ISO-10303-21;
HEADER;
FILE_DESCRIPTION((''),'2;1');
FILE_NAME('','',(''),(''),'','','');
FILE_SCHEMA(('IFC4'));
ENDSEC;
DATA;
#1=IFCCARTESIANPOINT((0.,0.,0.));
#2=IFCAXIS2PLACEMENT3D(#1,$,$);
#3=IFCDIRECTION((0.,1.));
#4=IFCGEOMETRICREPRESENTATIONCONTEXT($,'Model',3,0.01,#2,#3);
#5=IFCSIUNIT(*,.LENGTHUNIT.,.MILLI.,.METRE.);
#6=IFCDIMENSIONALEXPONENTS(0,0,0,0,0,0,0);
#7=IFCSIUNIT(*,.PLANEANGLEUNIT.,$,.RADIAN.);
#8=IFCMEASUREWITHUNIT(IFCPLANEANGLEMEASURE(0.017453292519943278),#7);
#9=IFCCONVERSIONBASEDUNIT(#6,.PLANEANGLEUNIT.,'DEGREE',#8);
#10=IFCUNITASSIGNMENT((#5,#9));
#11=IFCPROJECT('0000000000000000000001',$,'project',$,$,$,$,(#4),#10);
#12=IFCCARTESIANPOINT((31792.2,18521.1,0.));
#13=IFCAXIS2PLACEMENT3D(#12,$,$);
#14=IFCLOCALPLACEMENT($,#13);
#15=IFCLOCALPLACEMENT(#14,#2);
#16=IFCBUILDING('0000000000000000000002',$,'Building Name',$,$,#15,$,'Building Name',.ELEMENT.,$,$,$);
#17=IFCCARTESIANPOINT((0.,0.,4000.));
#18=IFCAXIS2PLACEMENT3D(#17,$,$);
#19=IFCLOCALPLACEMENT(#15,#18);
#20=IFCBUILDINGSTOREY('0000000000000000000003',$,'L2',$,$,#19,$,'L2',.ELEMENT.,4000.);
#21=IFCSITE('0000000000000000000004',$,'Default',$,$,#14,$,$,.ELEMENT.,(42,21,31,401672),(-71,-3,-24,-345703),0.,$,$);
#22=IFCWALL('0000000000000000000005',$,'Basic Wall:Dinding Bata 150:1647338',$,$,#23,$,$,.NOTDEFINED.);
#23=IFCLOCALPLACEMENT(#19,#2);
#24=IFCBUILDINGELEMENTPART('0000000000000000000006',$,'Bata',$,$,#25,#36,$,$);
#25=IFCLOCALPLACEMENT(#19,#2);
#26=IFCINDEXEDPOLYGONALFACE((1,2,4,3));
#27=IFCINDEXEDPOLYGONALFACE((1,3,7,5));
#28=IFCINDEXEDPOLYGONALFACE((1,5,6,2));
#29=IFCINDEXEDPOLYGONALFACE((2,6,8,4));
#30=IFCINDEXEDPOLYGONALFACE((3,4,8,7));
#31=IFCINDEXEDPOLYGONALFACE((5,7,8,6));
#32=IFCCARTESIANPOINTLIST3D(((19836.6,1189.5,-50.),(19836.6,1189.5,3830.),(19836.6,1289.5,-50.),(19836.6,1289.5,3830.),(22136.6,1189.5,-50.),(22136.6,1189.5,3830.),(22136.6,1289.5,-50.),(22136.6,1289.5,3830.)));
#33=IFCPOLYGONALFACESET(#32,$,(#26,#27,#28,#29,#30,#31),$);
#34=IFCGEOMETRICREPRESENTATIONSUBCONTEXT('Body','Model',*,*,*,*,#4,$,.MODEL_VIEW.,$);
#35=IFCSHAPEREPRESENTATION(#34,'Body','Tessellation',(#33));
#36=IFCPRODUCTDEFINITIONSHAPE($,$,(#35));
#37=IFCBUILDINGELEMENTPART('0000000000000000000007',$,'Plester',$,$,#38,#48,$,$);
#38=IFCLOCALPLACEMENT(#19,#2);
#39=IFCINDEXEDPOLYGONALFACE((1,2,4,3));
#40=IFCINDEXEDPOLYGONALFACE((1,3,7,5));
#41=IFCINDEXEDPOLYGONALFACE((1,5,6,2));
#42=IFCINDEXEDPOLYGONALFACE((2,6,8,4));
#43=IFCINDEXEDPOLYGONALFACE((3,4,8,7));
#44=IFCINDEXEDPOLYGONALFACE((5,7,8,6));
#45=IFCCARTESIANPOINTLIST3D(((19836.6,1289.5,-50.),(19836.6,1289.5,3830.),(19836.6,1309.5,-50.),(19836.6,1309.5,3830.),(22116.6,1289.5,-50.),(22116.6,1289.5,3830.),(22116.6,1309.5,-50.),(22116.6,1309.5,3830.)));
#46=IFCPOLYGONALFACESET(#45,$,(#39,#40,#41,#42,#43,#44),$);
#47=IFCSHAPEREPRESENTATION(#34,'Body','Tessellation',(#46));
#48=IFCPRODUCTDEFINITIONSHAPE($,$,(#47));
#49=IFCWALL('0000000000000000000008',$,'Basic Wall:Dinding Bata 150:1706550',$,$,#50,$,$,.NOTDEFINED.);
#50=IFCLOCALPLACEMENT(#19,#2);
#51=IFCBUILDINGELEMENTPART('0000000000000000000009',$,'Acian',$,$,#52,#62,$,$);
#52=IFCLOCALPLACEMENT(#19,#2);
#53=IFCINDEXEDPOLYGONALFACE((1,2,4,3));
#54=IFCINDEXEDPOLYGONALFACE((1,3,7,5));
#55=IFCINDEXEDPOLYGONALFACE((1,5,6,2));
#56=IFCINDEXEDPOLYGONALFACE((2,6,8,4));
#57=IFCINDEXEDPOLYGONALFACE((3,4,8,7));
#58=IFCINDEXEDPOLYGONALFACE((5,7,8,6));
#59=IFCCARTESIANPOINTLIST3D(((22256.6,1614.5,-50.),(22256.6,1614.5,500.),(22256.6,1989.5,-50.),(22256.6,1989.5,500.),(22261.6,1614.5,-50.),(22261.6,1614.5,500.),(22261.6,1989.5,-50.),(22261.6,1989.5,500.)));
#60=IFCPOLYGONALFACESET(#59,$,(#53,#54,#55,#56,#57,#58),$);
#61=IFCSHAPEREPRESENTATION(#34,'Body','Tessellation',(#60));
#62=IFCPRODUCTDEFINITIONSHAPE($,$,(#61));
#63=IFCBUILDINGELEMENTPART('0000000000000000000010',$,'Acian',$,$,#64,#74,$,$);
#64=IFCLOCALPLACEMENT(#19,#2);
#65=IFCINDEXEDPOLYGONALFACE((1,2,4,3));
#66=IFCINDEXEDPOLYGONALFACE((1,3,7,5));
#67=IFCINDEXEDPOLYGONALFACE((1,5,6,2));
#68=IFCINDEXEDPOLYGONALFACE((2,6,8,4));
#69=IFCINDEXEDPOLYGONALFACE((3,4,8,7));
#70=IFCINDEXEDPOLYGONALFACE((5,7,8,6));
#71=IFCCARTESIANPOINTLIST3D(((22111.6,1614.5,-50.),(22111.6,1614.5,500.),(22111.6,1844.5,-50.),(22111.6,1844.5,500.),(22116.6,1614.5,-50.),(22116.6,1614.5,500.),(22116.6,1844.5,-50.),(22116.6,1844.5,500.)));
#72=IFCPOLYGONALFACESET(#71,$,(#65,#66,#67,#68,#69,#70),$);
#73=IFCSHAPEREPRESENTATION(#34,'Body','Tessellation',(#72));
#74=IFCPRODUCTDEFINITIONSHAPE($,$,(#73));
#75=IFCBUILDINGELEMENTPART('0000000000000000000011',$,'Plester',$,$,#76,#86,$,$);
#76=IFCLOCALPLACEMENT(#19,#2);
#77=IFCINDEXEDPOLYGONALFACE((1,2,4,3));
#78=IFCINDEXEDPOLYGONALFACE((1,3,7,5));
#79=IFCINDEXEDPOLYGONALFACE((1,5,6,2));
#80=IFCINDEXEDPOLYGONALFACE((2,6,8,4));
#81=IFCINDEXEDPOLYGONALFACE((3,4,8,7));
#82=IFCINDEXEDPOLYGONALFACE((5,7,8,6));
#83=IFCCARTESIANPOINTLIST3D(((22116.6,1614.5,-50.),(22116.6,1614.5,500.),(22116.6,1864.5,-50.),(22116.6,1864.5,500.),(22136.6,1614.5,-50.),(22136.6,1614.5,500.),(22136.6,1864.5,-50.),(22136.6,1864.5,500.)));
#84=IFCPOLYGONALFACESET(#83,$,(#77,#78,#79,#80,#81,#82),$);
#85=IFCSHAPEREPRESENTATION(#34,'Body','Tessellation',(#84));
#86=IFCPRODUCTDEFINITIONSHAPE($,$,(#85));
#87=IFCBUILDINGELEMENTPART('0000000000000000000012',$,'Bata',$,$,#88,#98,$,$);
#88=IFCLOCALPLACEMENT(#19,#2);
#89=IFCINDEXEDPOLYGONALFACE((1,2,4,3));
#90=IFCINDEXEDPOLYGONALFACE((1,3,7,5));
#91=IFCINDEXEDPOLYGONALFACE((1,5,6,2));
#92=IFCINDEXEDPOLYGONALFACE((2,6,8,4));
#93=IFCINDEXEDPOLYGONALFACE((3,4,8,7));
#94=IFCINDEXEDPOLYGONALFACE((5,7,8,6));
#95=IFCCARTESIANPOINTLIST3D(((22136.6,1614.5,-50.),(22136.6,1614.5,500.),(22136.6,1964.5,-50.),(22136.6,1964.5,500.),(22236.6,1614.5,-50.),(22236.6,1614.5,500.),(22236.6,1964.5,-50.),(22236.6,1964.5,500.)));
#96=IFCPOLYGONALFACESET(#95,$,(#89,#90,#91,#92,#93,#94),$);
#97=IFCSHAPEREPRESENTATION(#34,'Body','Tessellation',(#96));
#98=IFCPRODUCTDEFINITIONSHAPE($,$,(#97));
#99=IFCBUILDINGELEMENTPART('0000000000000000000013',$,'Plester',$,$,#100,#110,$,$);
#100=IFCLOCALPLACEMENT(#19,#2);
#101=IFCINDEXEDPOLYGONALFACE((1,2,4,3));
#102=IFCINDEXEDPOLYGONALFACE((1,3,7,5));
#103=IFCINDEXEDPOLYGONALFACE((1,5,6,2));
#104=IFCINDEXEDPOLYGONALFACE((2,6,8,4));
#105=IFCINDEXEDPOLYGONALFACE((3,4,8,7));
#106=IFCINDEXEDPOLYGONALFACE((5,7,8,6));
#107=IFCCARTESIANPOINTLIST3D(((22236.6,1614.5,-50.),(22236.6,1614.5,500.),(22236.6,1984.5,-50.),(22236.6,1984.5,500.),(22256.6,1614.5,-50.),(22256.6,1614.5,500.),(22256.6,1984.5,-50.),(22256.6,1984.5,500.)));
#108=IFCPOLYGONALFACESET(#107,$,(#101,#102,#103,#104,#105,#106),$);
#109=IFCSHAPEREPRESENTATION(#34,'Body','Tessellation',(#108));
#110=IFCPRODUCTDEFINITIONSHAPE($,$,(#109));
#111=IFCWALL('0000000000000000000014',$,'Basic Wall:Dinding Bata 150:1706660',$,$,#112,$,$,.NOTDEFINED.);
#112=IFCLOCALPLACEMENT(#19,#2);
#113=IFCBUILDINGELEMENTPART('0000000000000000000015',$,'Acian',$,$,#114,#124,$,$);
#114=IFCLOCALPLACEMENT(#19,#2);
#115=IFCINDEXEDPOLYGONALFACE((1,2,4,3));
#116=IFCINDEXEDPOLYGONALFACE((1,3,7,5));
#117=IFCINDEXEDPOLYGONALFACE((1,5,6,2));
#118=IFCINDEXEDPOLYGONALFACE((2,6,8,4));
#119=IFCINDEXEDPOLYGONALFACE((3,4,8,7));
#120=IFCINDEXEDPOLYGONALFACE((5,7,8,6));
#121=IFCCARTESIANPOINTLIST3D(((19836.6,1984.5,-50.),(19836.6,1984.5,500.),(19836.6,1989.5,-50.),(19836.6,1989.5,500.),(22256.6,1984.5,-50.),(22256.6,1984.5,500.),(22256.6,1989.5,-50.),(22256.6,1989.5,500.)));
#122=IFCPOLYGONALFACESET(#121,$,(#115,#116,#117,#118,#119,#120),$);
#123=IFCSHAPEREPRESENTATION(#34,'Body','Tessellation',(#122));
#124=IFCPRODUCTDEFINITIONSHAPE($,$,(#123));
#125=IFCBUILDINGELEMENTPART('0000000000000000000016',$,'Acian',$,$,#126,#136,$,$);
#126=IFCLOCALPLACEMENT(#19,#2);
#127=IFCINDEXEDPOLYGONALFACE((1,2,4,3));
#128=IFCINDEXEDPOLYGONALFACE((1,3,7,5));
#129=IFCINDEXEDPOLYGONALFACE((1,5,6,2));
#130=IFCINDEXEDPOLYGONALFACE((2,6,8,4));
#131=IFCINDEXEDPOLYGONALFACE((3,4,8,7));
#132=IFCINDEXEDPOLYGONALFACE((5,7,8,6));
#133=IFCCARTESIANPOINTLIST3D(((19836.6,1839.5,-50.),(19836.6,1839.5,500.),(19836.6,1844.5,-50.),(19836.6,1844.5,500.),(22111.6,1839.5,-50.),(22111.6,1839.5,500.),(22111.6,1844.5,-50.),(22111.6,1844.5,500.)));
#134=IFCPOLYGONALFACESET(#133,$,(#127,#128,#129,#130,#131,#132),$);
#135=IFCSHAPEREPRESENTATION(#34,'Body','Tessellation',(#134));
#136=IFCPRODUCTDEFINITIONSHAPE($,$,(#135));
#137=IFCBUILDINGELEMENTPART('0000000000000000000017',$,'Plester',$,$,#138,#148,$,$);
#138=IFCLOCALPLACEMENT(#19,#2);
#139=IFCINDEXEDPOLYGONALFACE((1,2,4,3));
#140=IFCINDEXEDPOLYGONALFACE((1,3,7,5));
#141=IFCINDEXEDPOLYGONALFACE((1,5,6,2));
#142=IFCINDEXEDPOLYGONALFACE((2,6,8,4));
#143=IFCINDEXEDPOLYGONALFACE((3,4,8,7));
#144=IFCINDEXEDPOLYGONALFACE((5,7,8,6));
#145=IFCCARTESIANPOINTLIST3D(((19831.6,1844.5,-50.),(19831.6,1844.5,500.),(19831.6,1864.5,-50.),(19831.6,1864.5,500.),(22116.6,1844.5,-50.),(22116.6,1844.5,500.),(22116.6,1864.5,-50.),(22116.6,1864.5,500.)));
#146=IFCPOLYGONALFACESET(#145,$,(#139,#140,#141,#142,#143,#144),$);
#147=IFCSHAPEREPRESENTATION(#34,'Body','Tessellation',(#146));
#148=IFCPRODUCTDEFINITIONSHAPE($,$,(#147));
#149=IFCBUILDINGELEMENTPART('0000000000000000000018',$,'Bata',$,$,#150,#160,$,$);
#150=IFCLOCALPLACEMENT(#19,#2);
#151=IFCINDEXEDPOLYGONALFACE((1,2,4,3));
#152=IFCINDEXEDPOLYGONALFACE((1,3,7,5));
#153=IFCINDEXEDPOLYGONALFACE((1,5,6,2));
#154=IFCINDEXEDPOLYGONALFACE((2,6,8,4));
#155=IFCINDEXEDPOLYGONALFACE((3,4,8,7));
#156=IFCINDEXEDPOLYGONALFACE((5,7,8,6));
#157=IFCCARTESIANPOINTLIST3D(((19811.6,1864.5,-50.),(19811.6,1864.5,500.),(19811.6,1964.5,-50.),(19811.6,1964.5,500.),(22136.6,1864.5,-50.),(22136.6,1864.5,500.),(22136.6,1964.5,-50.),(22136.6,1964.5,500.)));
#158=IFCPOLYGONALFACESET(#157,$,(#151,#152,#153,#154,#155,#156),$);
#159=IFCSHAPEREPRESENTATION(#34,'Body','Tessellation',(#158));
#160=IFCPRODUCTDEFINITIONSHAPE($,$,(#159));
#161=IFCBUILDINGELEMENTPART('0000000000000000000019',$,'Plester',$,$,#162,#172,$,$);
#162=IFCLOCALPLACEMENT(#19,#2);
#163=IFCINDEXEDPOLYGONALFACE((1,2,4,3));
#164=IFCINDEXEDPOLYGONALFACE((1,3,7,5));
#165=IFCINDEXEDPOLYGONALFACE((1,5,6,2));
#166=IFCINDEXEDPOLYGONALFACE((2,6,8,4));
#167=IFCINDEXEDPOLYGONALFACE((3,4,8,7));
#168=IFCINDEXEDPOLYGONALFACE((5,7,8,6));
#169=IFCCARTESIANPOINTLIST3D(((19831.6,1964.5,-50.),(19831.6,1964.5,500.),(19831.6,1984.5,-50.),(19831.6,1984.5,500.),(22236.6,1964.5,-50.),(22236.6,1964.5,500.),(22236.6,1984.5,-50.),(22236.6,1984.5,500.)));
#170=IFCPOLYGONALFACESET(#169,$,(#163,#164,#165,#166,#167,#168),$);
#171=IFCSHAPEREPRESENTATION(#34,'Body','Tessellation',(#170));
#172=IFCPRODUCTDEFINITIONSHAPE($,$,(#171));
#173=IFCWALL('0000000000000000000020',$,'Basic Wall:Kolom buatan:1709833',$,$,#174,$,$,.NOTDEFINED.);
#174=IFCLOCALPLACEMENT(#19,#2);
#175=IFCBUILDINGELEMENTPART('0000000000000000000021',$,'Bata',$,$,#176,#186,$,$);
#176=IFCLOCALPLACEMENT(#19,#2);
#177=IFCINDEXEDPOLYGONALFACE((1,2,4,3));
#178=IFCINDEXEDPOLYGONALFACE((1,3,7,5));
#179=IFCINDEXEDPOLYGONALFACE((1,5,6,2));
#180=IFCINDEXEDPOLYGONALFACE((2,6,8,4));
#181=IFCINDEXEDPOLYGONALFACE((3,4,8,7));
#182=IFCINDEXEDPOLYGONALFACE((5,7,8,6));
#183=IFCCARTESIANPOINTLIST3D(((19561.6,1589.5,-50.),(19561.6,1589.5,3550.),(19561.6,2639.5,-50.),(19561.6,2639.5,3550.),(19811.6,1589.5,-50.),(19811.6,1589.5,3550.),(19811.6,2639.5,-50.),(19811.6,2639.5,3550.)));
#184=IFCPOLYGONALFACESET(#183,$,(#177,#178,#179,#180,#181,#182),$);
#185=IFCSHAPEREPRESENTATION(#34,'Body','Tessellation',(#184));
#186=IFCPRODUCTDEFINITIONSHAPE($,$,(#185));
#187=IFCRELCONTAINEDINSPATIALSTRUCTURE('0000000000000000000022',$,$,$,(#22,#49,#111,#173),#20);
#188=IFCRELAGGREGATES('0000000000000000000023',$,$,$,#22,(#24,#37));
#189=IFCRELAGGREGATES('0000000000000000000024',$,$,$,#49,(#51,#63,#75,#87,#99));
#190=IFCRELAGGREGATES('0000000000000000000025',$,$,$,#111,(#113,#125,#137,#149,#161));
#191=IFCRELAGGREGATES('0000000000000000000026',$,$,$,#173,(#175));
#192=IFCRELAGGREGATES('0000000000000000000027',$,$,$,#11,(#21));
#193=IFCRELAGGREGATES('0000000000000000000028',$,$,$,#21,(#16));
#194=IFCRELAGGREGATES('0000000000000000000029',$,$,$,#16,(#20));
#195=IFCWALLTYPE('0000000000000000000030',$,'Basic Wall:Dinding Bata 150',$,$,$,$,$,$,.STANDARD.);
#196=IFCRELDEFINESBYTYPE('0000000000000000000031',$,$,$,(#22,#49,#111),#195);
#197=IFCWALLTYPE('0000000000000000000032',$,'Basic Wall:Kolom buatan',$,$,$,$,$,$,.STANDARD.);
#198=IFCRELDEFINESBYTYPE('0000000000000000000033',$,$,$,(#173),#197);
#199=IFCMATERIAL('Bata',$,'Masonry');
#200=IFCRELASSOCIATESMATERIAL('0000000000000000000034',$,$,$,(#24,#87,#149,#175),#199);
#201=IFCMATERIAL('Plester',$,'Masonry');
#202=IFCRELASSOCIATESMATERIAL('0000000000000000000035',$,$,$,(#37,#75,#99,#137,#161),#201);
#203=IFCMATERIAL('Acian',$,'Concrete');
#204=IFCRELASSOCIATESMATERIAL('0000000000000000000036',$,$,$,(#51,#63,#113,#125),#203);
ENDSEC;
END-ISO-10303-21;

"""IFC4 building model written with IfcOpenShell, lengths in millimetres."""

from ifc_helpers import new_model, entity, si_unit, converted_unit, direction, frame, origin, place, context, subcontext, project, spatial, indexed_curve, outline, extrude, material, type_object, element, aggregate, save


model = new_model("IFC4")

# Units and contexts
model_context = context("Model", 3, precision=0.01, world=origin(), true_north=direction((0.0, 1.0)))
body_context = subcontext(model_context, "Body", "Model", "MODEL_VIEW")
ifc_project = project(units=[si_unit("LENGTHUNIT", "METRE", prefix="MILLI"), converted_unit("PLANEANGLEUNIT", "DEGREE", entity("IfcPlaneAngleMeasure", 0.017453292519943278), si_unit("PLANEANGLEUNIT", "RADIAN"), dimensions=[0, 0, 0, 0, 0, 0, 0])], contexts=[model_context])

# Site, building, storey
site_placement = place(None, frame((31792.2, 18521.1, 0.0)))
site = spatial("IfcSite", under=ifc_project, at=site_placement, Name="Default", CompositionType="ELEMENT", RefLatitude=(42, 21, 31, 401672), RefLongitude=(-71, -3, -24, -345703), RefElevation=0.0)
building_placement = place(site_placement, origin())
building = spatial("IfcBuilding", under=site, at=building_placement, Name="Building Name", LongName="Building Name", CompositionType="ELEMENT")
storey_placement = place(building_placement, frame((0.0, 0.0, 4000.0)))
storey = spatial("IfcBuildingStorey", under=building, at=storey_placement, Name="L2", LongName="L2", CompositionType="ELEMENT", Elevation=4000.0)

# Shared definitions
wall_type_1 = type_object("IfcWallType", Name="Basic Wall:Dinding Bata 150", PredefinedType="STANDARD")
ifc_material_1 = material(Name="Acian", Category="Concrete")
ifc_material_2 = material(Name="Plester", Category="Masonry")

# Walls, building element parts
ifc_material_3 = material(Name="Bata", Category="Masonry")
wall_1_placement = place(storey_placement, frame((22111.6, 1239.5, -50.0), z_axis=(0.0, 0.0, 1.0), x_axis=(-1.0, 0.0, 0.0)))
wall_1 = element("IfcWall", 1, at=wall_1_placement, inside=storey, type_object=wall_type_1, Name="Basic Wall:Dinding Bata 150:1647338", PredefinedType="NOTDEFINED")
building_element_part_1_placement = place(wall_1_placement, origin())
building_element_part_1 = element("IfcBuildingElementPart", 2, at=building_element_part_1_placement, material=ifc_material_3, Name="Bata", context=body_context, shape_type="SweptSolid", body=[
    extrude(outline(indexed_curve([(-50.0, -1150.0), (50.0, -1150.0), (50.0, 1150.0), (-50.0, 1150.0), (-50.0, -1150.0)], self_intersect=False)), frame((1125.0, 0.0, 0.0), z_axis=(0.0, 0.0, 1.0), x_axis=(0.0, 1.0, 0.0)), (0.0, 0.0, 1.0), 3880.0),
])
building_element_part_2_placement = place(wall_1_placement, origin())
building_element_part_2 = element("IfcBuildingElementPart", 3, at=building_element_part_2_placement, material=ifc_material_2, Name="Plester", context=body_context, shape_type="SweptSolid", body=[
    extrude(outline(indexed_curve([(-10.0, -1140.0), (10.0, -1140.0), (10.0, 1140.0), (-10.0, 1140.0), (-10.0, -1140.0)], self_intersect=False)), frame((1135.0, -60.0, 0.0), z_axis=(0.0, 0.0, 1.0), x_axis=(0.0, 1.0, 0.0)), (0.0, 0.0, 1.0), 3880.0),
])
aggregate(wall_1, [building_element_part_1, building_element_part_2])
wall_2_placement = place(storey_placement, frame((22186.6, 1614.5, -50.0), z_axis=(0.0, 0.0, 1.0), x_axis=(0.0, 1.0, 0.0)))
wall_2 = element("IfcWall", 4, at=wall_2_placement, inside=storey, type_object=wall_type_1, Name="Basic Wall:Dinding Bata 150:1706550", PredefinedType="NOTDEFINED")
building_element_part_3_placement = place(wall_2_placement, origin())
building_element_part_3 = element("IfcBuildingElementPart", 5, at=building_element_part_3_placement, material=ifc_material_1, Name="Acian", context=body_context, shape_type="SweptSolid", body=[
    extrude(outline(indexed_curve([(-187.5, -2.5), (187.5, -2.5), (187.5, 2.5), (-187.5, 2.5), (-187.5, -2.5)], self_intersect=False)), frame((187.5, -72.5, 0.0), z_axis=(0.0, 0.0, 1.0), x_axis=(-1.0, 0.0, 0.0)), (0.0, 0.0, 1.0), 550.0),
])
building_element_part_4_placement = place(wall_2_placement, origin())
building_element_part_4 = element("IfcBuildingElementPart", 6, at=building_element_part_4_placement, material=ifc_material_1, Name="Acian", context=body_context, shape_type="SweptSolid", body=[
    extrude(outline(indexed_curve([(-115.0, -2.5), (115.0, -2.5), (115.0, 2.5), (-115.0, 2.5), (-115.0, -2.5)], self_intersect=False)), frame((115.0, 72.5, 0.0), z_axis=(0.0, 0.0, 1.0), x_axis=(-1.0, 0.0, 0.0)), (0.0, 0.0, 1.0), 550.0),
])
building_element_part_5_placement = place(wall_2_placement, origin())
building_element_part_5 = element("IfcBuildingElementPart", 7, at=building_element_part_5_placement, material=ifc_material_2, Name="Plester", context=body_context, shape_type="SweptSolid", body=[
    extrude(outline(indexed_curve([(-125.0, -10.0), (125.0, -10.0), (125.0, 10.0), (-125.0, 10.0), (-125.0, -10.0)], self_intersect=False)), frame((125.0, 60.0, 0.0), z_axis=(0.0, 0.0, 1.0), x_axis=(-1.0, 0.0, 0.0)), (0.0, 0.0, 1.0), 550.0),
])
building_element_part_6_placement = place(wall_2_placement, origin())
building_element_part_6 = element("IfcBuildingElementPart", 8, at=building_element_part_6_placement, material=ifc_material_3, Name="Bata", context=body_context, shape_type="SweptSolid", body=[
    extrude(outline(indexed_curve([(-175.0, -50.0), (175.0, -50.0), (175.0, 50.0), (-175.0, 50.0), (-175.0, -50.0)], self_intersect=False)), frame((175.0, 0.0, 0.0), z_axis=(0.0, 0.0, 1.0), x_axis=(-1.0, 0.0, 0.0)), (0.0, 0.0, 1.0), 550.0),
])
building_element_part_7_placement = place(wall_2_placement, origin())
building_element_part_7 = element("IfcBuildingElementPart", 9, at=building_element_part_7_placement, material=ifc_material_2, Name="Plester", context=body_context, shape_type="SweptSolid", body=[
    extrude(outline(indexed_curve([(-185.0, -10.0), (185.0, -10.0), (185.0, 10.0), (-185.0, 10.0), (-185.0, -10.0)], self_intersect=False)), frame((185.0, -60.0, 0.0), z_axis=(0.0, 0.0, 1.0), x_axis=(-1.0, 0.0, 0.0)), (0.0, 0.0, 1.0), 550.0),
])
aggregate(wall_2, [building_element_part_3, building_element_part_4, building_element_part_5, building_element_part_6, building_element_part_7])
wall_3_placement = place(storey_placement, frame((22111.6, 1914.5, -50.0), z_axis=(0.0, 0.0, 1.0), x_axis=(-1.0, 0.0, 0.0)))
wall_3 = element("IfcWall", 10, at=wall_3_placement, inside=storey, type_object=wall_type_1, Name="Basic Wall:Dinding Bata 150:1706660", PredefinedType="NOTDEFINED")
building_element_part_8_placement = place(wall_3_placement, origin())
building_element_part_8 = element("IfcBuildingElementPart", 11, at=building_element_part_8_placement, material=ifc_material_1, Name="Acian", context=body_context, shape_type="SweptSolid", body=[
    extrude(outline(indexed_curve([(-2.5, -1210.0), (2.5, -1210.0), (2.5, 1210.0), (-2.5, 1210.0), (-2.5, -1210.0)], self_intersect=False)), frame((1065.0, -72.5, 0.0), z_axis=(0.0, 0.0, 1.0), x_axis=(0.0, 1.0, 0.0)), (0.0, 0.0, 1.0), 550.0),
])
building_element_part_9_placement = place(wall_3_placement, origin())
building_element_part_9 = element("IfcBuildingElementPart", 12, at=building_element_part_9_placement, material=ifc_material_1, Name="Acian", context=body_context, shape_type="SweptSolid", body=[
    extrude(outline(indexed_curve([(-2.5, -1137.5), (2.5, -1137.5), (2.5, 1137.5), (-2.5, 1137.5), (-2.5, -1137.5)], self_intersect=False)), frame((1137.5, 72.5, 0.0), z_axis=(0.0, 0.0, 1.0), x_axis=(0.0, 1.0, 0.0)), (0.0, 0.0, 1.0), 550.0),
])
building_element_part_10_placement = place(wall_3_placement, origin())
building_element_part_10 = element("IfcBuildingElementPart", 13, at=building_element_part_10_placement, material=ifc_material_2, Name="Plester", context=body_context, shape_type="SweptSolid", body=[
    extrude(outline(indexed_curve([(-10.0, -1142.5), (10.0, -1142.5), (10.0, 1142.5), (-10.0, 1142.5), (-10.0, -1142.5)], self_intersect=False)), frame((1137.5, 60.0, 0.0), z_axis=(0.0, 0.0, 1.0), x_axis=(0.0, 1.0, 0.0)), (0.0, 0.0, 1.0), 550.0),
])
building_element_part_11_placement = place(wall_3_placement, origin())
building_element_part_11 = element("IfcBuildingElementPart", 14, at=building_element_part_11_placement, material=ifc_material_3, Name="Bata", context=body_context, shape_type="SweptSolid", body=[
    extrude(outline(indexed_curve([(-50.0, -1162.5), (50.0, -1162.5), (50.0, 1162.5), (-50.0, 1162.5), (-50.0, -1162.5)], self_intersect=False)), frame((1137.5, 0.0, 0.0), z_axis=(0.0, 0.0, 1.0), x_axis=(0.0, 1.0, 0.0)), (0.0, 0.0, 1.0), 550.0),
])
building_element_part_12_placement = place(wall_3_placement, origin())
building_element_part_12 = element("IfcBuildingElementPart", 15, at=building_element_part_12_placement, material=ifc_material_2, Name="Plester", context=body_context, shape_type="SweptSolid", body=[
    extrude(outline(indexed_curve([(-10.0, -1202.5), (10.0, -1202.5), (10.0, 1202.5), (-10.0, 1202.5), (-10.0, -1202.5)], self_intersect=False)), frame((1077.5, -60.0, 0.0), z_axis=(0.0, 0.0, 1.0), x_axis=(0.0, 1.0, 0.0)), (0.0, 0.0, 1.0), 550.0),
])
aggregate(wall_3, [building_element_part_8, building_element_part_9, building_element_part_10, building_element_part_11, building_element_part_12])

# Wall, building element part
wall_type_2 = type_object("IfcWallType", Name="Basic Wall:Kolom buatan", PredefinedType="STANDARD")
wall_4_placement = place(storey_placement, frame((19686.6, 1589.5, -50.0), z_axis=(0.0, 0.0, 1.0), x_axis=(0.0, 1.0, 0.0)))
wall_4 = element("IfcWall", 16, at=wall_4_placement, inside=storey, type_object=wall_type_2, Name="Basic Wall:Kolom buatan:1709833", PredefinedType="NOTDEFINED")
building_element_part_13_placement = place(wall_4_placement, origin())
building_element_part_13 = element("IfcBuildingElementPart", 17, at=building_element_part_13_placement, material=ifc_material_3, Name="Bata", context=body_context, shape_type="SweptSolid", body=[
    extrude(outline(indexed_curve([(-525.0, -125.0), (525.0, -125.0), (525.0, 125.0), (-525.0, 125.0), (-525.0, -125.0)], self_intersect=False)), frame((525.0, 0.0, 0.0), z_axis=(0.0, 0.0, 1.0), x_axis=(-1.0, 0.0, 0.0)), (0.0, 0.0, 1.0), 3600.0),
])
aggregate(wall_4, [building_element_part_13])

save(model, "model.ifc")
